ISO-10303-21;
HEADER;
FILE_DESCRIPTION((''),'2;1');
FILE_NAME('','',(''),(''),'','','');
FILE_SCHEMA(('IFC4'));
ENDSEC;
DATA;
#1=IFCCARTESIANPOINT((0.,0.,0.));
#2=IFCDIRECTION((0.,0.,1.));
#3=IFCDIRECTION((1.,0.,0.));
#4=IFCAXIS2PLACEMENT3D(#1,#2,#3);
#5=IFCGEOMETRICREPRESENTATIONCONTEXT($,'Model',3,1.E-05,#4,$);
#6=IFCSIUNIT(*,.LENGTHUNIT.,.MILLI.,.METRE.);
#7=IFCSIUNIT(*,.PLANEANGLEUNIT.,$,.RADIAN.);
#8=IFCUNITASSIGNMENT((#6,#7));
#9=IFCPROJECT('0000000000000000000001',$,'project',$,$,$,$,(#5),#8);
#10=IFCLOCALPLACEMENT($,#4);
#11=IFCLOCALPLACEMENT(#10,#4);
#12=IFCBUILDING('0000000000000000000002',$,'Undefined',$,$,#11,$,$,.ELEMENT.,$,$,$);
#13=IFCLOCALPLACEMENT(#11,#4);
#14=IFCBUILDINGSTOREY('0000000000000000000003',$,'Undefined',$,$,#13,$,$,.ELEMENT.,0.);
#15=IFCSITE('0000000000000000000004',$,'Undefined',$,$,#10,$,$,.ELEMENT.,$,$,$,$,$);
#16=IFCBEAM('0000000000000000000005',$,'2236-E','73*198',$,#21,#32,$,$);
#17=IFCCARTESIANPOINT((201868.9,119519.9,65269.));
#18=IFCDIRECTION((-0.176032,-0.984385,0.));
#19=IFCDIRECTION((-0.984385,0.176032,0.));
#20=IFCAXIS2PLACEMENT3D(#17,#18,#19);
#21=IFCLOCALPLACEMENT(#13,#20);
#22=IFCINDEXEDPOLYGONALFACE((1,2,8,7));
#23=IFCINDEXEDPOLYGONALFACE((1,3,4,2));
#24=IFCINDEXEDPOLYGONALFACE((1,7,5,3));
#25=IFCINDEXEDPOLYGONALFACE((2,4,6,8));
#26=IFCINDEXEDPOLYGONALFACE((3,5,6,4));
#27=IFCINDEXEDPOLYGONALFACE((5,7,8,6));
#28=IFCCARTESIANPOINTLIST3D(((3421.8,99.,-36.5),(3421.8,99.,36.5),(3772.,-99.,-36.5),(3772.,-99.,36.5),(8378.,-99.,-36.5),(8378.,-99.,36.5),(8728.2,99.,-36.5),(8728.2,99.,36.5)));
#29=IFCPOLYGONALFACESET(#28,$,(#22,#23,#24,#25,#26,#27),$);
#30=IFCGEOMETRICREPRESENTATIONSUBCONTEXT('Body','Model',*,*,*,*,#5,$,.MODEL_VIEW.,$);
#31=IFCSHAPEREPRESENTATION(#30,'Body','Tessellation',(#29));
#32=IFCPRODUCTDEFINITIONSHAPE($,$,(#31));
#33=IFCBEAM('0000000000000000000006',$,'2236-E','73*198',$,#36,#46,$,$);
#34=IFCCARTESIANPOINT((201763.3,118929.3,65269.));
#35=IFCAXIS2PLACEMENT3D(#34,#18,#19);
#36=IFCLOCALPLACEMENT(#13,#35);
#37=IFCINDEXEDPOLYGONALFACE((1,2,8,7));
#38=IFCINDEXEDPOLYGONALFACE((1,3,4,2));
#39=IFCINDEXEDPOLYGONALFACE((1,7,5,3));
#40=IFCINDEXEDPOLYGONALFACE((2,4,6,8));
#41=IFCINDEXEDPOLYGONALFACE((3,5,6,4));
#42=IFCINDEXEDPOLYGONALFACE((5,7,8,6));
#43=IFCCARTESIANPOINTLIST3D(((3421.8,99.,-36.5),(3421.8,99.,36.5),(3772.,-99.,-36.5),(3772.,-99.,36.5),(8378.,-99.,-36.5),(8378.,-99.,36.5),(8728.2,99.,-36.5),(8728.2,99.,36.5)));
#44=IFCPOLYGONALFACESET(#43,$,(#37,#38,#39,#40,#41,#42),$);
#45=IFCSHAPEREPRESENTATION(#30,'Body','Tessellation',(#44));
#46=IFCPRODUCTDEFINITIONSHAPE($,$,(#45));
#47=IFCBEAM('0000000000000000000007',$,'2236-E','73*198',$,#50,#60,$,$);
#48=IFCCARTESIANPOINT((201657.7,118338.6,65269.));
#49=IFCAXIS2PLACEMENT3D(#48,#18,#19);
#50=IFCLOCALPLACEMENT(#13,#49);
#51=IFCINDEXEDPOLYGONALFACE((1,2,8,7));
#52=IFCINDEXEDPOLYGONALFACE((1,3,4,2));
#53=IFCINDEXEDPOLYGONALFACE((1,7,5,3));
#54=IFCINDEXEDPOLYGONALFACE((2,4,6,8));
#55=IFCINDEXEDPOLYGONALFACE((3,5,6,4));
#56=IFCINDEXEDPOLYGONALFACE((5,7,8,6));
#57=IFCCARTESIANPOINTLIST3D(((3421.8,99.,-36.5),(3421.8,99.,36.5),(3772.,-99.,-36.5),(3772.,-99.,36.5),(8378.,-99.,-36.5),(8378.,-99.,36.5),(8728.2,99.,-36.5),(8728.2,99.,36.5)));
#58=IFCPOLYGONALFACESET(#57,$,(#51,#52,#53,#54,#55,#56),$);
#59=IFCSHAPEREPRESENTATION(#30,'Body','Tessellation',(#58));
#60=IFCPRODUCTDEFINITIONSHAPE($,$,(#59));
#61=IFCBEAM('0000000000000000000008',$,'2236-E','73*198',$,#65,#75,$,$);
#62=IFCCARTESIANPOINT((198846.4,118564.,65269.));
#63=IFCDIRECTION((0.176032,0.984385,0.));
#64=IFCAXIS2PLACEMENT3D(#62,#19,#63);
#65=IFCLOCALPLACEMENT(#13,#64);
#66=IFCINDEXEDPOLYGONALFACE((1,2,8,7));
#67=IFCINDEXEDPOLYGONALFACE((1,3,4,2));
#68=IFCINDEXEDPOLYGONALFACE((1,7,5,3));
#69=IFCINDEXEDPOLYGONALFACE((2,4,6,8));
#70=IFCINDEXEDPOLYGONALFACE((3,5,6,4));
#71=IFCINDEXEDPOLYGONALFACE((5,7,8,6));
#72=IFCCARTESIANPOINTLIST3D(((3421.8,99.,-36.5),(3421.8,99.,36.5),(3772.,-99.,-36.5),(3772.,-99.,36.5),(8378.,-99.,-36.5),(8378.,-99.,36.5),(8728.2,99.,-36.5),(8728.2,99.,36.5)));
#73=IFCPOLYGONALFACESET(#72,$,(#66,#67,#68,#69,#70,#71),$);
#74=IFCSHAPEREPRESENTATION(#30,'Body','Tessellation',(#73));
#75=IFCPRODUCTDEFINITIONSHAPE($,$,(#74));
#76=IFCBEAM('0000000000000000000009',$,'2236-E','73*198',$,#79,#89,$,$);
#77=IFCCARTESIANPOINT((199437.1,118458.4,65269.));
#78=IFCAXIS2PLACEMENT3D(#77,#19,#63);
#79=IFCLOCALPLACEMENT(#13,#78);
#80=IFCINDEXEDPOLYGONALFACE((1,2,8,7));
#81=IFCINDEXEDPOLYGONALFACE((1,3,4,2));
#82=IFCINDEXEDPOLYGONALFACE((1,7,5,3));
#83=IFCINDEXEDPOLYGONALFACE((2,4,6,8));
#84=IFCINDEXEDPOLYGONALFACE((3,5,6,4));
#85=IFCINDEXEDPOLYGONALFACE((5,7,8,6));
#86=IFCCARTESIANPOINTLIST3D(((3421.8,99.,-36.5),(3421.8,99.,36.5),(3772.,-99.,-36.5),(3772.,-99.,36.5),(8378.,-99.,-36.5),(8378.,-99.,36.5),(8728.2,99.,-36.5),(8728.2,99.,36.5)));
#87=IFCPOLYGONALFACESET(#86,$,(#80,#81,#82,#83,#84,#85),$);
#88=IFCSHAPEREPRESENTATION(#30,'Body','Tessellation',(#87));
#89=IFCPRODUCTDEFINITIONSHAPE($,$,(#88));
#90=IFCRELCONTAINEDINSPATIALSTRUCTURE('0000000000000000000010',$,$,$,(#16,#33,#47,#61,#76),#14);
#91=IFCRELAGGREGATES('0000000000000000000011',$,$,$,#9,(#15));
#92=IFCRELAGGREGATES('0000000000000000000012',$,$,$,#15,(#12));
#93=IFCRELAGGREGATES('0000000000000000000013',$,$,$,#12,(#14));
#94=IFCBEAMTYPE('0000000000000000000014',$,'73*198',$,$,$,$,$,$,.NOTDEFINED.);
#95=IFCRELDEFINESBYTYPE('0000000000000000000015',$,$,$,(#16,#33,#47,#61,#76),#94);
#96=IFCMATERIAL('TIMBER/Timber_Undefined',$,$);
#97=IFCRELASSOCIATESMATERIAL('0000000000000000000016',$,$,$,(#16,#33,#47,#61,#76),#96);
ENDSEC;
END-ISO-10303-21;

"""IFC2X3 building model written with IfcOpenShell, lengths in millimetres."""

from ifc_helpers import new_model, si_unit, frame, origin_with_axes, origin_2d_with_axis, place, context, subcontext, project, spatial, rectangle, extrude, clip, halfspace, material, type_object, element, save


model = new_model("IFC2X3")

# Units and contexts
model_context = context("Model", 3, precision=1e-05, world=origin_with_axes())
body_context = subcontext(model_context, "Body", "Model", "MODEL_VIEW")
ifc_project = project(units=[si_unit("LENGTHUNIT", "METRE", prefix="MILLI"), si_unit("PLANEANGLEUNIT", "RADIAN")], contexts=[model_context])

# Site, building, storey
site_placement = place(None, origin_with_axes())
site = spatial("IfcSite", under=ifc_project, at=site_placement, Name="Undefined", CompositionType="ELEMENT")
building_placement = place(site_placement, origin_with_axes())
building = spatial("IfcBuilding", under=site, at=building_placement, Name="Undefined", CompositionType="ELEMENT")
storey_placement = place(building_placement, origin_with_axes())
storey = spatial("IfcBuildingStorey", under=building, at=storey_placement, Name="Undefined", CompositionType="ELEMENT", Elevation=0.0)

# Shared definitions
ifc_material_1 = material(Name="TIMBER/Timber_Undefined")

# Beams
beam_type_1 = type_object("IfcBeamType", Name="73*198", PredefinedType="NOTDEFINED")
for number, where, z_axis, x_axis, name in (
    (1, (201868.9, 119519.9, 65269.0), (-0.176032, -0.984385, 0.0), (-0.984385, 0.176032, 0.0), "2236-E"),
    (2, (201763.3, 118929.3, 65269.0), (-0.176032, -0.984385, 0.0), (-0.984385, 0.176032, 0.0), "2236-E"),
    (3, (201657.7, 118338.6, 65269.0), (-0.176032, -0.984385, 0.0), (-0.984385, 0.176032, 0.0), "2236-E"),
    (4, (198846.4, 118564.0, 65269.0), (-0.984385, 0.176032, 0.0), (0.176032, 0.984385, 0.0), "2236-E"),
    (5, (199437.1, 118458.4, 65269.0), (-0.984385, 0.176032, 0.0), (0.176032, 0.984385, 0.0), "2236-E"),
):
    element("IfcBeam", number, at=place(storey_placement, frame(where, z_axis=z_axis, x_axis=x_axis)), inside=storey, type_object=beam_type_1, material=ifc_material_1, Name=name, Description="73*198", context=body_context, shape_type="Clipping", body=[
        clip(clip(extrude(rectangle(XDim=198.0, YDim=73.0, at=origin_2d_with_axis()), frame((14325.0, 0.0, 0.0), z_axis=(-1.0, 0.0, 0.0), x_axis=(0.0, -1.0, 0.0)), (0.0, 0.0, 1.0), 14325.0), halfspace(frame((3772.0, -99.0, 36.5), z_axis=(-0.492144, -0.870514, 0.0), x_axis=(0.0, 0.0, -1.0)), False)), halfspace(frame((8728.2, 99.0, 36.5), z_axis=(0.492144, -0.870514, 0.0), x_axis=(0.0, 0.0, -1.0)), False)),
    ])

save(model, "model.ifc")
